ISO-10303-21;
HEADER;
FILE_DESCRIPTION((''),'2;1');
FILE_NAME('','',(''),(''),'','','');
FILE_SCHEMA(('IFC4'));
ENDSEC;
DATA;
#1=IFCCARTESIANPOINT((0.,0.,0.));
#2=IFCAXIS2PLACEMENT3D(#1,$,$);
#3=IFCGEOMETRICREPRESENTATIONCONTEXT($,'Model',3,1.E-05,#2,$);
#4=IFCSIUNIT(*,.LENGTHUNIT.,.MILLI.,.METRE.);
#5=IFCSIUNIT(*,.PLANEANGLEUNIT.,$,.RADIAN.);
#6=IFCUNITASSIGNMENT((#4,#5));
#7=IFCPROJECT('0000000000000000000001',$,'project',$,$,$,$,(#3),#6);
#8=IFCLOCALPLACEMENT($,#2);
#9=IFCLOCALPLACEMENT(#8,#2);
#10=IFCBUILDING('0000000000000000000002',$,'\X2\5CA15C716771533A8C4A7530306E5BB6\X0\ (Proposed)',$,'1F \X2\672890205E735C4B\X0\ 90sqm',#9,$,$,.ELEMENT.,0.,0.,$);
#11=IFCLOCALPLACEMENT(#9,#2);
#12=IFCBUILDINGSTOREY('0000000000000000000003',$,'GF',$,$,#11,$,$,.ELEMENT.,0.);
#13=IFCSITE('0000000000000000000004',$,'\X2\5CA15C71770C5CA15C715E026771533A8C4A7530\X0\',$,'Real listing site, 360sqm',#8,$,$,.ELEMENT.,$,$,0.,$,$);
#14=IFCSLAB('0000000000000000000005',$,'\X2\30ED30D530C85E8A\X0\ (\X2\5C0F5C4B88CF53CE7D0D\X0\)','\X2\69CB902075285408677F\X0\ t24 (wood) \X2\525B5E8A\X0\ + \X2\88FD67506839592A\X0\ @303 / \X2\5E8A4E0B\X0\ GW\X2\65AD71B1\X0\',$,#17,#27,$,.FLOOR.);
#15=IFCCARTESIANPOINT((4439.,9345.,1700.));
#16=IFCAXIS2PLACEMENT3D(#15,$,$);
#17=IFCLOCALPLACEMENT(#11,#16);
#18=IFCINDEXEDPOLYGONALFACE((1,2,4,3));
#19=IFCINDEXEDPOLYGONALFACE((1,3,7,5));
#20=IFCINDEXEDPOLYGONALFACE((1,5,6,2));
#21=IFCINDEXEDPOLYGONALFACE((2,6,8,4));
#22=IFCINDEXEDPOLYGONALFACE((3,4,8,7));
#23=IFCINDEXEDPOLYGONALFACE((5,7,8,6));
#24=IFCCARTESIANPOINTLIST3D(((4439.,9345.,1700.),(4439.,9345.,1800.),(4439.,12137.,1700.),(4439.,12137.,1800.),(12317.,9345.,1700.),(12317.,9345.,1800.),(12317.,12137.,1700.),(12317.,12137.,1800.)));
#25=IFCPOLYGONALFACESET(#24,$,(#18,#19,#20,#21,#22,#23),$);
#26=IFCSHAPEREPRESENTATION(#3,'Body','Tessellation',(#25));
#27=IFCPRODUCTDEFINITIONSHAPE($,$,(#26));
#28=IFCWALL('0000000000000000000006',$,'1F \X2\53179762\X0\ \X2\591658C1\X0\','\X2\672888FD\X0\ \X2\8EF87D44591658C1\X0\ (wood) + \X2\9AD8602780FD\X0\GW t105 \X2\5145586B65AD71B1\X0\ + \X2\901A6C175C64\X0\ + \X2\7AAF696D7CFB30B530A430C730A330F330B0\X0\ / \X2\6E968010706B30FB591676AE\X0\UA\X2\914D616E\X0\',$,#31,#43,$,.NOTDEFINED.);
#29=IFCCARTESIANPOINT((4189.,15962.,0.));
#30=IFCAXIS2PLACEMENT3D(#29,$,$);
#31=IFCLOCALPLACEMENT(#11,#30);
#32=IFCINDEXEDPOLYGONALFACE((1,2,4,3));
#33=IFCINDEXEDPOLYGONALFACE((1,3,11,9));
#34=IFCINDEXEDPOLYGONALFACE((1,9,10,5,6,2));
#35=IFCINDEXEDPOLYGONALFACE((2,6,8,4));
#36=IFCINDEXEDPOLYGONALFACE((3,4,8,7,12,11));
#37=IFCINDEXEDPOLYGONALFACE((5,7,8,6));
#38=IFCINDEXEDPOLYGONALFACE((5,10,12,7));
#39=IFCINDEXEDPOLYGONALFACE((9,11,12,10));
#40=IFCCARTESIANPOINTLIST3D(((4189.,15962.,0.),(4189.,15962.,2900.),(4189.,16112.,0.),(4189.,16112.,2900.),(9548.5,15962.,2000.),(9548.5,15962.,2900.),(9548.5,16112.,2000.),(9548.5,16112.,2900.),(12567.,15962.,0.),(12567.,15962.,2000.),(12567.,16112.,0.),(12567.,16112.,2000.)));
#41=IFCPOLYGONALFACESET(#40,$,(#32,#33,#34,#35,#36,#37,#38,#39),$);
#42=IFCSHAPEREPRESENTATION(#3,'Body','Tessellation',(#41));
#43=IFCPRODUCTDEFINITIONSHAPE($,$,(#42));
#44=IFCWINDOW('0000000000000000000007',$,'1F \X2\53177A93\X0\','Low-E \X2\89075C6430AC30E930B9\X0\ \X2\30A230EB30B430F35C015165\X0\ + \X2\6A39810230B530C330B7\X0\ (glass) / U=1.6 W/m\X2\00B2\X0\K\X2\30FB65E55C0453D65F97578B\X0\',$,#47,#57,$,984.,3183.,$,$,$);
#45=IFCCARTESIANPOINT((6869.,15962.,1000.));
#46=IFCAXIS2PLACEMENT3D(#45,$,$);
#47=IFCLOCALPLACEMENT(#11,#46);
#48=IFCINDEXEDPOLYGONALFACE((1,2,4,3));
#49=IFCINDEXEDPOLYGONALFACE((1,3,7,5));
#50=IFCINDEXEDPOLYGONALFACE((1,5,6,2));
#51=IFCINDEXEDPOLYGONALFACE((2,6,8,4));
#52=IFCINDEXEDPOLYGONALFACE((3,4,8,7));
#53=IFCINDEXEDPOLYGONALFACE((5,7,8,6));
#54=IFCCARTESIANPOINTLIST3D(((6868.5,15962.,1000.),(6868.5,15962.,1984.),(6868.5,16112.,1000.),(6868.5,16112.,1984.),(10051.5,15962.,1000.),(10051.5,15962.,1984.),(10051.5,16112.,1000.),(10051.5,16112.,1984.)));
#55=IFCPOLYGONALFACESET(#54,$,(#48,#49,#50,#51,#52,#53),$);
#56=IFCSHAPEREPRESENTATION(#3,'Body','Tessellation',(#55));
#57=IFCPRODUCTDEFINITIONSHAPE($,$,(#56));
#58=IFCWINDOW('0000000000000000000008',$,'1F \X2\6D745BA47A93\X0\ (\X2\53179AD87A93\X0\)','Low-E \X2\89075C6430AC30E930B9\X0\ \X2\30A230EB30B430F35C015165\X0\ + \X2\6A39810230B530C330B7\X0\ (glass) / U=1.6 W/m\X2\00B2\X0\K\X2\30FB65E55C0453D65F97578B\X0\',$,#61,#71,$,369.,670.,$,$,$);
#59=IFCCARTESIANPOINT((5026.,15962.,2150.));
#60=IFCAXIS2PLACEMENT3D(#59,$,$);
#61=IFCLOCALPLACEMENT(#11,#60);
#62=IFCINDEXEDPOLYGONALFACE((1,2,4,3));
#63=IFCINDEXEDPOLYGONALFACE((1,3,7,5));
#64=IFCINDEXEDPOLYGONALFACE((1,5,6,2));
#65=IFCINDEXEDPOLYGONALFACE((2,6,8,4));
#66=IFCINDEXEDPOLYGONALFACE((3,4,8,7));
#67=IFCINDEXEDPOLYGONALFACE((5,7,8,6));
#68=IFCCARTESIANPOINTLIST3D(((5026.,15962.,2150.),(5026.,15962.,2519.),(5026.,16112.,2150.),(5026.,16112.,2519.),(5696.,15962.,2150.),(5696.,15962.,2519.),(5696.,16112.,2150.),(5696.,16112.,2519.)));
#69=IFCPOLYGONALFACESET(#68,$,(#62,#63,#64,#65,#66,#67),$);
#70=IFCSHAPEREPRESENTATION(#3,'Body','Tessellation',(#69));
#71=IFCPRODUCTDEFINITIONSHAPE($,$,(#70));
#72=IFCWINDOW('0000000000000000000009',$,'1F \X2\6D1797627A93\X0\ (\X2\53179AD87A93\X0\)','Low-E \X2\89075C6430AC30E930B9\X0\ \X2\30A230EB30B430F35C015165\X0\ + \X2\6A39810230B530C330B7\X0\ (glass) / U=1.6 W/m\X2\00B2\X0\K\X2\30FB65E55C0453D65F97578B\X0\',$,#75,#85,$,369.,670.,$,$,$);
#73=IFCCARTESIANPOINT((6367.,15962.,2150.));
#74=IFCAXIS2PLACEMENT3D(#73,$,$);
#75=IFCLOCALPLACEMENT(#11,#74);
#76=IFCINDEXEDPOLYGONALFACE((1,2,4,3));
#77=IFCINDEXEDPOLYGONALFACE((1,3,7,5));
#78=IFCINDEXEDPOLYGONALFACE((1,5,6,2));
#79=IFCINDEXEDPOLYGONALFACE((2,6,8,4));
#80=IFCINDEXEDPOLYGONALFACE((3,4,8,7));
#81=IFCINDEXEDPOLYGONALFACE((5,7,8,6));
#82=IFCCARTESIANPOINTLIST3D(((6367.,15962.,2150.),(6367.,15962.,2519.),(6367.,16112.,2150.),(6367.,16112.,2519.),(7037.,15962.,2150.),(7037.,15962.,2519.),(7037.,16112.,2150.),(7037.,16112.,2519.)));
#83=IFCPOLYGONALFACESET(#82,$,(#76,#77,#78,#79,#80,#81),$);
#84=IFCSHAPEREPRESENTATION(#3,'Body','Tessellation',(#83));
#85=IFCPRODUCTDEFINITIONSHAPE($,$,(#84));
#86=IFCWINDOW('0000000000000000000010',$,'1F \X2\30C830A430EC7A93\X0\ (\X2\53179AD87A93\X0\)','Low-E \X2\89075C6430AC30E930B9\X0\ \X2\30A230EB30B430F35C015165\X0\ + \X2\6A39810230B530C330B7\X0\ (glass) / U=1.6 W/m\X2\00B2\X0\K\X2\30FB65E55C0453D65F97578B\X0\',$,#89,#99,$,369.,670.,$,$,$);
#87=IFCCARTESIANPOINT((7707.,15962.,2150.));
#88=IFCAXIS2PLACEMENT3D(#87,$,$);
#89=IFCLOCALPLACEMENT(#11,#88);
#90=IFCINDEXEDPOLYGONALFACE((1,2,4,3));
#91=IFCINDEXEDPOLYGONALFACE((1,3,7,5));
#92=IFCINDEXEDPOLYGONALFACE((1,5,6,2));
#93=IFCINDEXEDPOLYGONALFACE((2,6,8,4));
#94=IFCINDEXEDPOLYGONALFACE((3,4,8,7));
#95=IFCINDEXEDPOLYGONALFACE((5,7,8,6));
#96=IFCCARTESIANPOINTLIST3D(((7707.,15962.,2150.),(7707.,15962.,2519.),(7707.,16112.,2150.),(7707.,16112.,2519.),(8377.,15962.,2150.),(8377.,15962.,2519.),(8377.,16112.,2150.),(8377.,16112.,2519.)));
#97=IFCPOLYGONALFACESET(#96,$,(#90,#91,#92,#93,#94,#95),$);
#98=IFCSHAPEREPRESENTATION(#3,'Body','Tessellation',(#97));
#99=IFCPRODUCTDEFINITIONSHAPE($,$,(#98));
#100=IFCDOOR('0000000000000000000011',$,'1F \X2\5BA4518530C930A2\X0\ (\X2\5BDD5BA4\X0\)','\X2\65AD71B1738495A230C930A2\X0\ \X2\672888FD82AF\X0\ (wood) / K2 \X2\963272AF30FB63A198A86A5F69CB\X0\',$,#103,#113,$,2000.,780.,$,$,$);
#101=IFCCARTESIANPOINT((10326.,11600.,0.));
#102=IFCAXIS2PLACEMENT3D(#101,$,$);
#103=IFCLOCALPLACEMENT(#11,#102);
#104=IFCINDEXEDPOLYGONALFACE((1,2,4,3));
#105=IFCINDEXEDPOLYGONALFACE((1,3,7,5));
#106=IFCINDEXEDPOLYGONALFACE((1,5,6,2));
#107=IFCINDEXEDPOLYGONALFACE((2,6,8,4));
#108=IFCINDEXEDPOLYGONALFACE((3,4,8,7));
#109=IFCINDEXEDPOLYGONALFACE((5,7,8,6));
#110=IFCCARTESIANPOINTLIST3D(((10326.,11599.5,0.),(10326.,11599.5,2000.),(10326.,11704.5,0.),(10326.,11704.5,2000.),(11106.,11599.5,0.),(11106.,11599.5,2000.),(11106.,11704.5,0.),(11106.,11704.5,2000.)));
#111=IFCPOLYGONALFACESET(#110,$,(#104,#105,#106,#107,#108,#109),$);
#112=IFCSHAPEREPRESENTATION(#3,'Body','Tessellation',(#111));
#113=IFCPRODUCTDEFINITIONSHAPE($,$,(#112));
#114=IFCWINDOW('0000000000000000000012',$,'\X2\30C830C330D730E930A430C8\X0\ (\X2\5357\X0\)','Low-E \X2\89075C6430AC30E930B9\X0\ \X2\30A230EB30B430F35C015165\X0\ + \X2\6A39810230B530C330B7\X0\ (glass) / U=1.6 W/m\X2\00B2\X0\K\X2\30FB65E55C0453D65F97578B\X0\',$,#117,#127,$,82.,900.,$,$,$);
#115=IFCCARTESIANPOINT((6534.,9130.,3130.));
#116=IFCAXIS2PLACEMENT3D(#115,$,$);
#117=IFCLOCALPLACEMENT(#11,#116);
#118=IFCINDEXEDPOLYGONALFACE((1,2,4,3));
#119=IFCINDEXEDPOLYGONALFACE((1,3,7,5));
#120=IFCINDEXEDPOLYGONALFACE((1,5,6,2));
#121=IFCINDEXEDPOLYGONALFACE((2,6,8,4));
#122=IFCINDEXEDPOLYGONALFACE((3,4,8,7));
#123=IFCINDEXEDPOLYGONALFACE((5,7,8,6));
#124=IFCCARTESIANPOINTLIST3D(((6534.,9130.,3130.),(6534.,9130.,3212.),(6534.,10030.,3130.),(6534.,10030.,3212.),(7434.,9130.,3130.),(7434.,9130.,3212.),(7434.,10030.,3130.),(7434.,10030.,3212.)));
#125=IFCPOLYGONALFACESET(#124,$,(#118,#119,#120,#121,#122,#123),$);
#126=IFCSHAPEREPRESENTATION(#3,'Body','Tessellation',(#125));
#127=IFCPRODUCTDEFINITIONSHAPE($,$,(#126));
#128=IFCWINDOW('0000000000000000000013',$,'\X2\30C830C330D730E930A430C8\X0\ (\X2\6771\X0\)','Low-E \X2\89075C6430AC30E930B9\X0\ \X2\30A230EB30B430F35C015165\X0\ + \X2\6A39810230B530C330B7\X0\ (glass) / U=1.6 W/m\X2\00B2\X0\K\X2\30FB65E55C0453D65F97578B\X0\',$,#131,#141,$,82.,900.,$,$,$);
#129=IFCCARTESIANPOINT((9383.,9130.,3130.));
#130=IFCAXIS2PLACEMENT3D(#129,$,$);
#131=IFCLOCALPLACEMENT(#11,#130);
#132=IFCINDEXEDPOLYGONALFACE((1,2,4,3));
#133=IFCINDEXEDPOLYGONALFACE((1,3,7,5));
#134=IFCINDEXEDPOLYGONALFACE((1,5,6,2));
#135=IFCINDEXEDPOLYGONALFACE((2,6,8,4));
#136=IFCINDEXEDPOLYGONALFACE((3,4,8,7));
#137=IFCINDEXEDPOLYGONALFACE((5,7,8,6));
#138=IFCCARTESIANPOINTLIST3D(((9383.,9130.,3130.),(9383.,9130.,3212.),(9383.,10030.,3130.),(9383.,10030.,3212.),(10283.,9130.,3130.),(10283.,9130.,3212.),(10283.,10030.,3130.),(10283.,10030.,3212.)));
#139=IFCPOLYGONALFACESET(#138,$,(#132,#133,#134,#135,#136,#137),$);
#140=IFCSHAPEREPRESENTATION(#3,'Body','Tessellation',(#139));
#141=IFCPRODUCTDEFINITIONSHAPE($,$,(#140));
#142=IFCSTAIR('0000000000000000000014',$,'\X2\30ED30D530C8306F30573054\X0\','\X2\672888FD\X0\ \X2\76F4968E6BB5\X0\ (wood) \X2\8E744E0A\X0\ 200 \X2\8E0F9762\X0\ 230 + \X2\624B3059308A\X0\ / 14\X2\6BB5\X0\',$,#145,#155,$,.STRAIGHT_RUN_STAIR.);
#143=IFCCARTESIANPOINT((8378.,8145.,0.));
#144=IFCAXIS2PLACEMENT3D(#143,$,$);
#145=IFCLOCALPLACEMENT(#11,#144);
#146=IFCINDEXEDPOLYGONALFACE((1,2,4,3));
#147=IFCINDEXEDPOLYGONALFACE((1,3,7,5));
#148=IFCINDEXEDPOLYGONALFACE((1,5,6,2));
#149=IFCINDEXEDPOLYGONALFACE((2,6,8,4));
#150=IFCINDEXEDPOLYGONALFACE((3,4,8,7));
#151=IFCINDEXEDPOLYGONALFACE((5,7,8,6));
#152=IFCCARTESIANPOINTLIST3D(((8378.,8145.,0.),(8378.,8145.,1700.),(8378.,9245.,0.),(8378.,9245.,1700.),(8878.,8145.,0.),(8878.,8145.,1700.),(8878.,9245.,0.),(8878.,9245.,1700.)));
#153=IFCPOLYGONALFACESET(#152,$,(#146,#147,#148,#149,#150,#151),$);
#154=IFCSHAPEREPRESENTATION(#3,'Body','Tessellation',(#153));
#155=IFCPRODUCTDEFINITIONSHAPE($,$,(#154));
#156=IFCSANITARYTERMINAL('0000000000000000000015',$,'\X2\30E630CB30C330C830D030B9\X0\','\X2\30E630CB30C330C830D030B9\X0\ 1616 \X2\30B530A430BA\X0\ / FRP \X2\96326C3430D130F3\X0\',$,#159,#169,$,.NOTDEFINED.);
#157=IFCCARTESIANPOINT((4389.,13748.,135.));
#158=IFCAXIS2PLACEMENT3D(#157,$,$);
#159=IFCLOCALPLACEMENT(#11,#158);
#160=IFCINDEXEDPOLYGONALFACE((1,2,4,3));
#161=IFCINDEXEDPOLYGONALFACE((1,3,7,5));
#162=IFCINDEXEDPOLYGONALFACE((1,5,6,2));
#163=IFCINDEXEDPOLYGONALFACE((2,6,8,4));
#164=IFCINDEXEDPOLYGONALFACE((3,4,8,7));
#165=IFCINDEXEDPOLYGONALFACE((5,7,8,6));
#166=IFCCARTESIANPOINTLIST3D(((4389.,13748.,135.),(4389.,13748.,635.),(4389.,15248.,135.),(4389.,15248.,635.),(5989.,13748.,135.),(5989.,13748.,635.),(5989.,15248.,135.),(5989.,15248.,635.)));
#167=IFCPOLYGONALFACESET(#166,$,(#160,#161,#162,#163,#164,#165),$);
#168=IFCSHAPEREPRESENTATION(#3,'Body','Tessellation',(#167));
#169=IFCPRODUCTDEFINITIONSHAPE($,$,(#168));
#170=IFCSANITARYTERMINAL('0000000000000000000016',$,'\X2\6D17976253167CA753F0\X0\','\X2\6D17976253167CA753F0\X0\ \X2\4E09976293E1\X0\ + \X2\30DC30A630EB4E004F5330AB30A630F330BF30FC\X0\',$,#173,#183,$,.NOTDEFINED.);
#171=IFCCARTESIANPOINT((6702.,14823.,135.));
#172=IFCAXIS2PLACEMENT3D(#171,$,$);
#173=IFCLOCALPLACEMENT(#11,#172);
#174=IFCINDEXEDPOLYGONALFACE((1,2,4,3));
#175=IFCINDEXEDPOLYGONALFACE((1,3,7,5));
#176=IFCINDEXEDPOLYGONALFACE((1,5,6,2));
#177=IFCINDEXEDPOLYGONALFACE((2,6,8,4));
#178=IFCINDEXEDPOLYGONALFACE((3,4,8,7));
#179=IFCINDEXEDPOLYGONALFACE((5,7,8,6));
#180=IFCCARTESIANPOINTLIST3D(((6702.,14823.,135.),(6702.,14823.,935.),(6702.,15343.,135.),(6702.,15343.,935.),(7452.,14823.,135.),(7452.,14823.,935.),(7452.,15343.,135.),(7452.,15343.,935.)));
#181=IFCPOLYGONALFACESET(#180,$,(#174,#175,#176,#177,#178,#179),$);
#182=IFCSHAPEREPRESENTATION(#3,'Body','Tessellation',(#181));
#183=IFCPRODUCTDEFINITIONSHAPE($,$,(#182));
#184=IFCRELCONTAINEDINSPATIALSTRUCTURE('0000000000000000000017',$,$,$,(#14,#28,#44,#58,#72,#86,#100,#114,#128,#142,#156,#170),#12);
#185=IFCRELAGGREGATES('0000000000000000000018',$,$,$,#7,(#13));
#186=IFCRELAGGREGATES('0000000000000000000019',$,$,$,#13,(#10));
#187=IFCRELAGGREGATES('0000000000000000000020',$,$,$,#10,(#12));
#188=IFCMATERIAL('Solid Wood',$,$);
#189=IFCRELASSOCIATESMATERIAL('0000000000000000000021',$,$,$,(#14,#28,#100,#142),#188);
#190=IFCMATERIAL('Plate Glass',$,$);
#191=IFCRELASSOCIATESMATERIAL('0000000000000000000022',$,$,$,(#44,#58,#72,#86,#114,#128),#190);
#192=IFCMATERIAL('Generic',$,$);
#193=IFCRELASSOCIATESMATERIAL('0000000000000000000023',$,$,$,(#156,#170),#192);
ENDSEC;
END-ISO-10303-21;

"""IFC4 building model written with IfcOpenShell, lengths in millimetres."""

from ifc_helpers import new_model, si_unit, frame, frame_2d, origin, place, context, project, spatial, rectangle, extrude, material, element, fill, save


model = new_model("IFC4")

# Units and contexts
model_context = context("Model", 3, precision=1e-05, world=origin())
ifc_project = project(units=[si_unit("LENGTHUNIT", "METRE", prefix="MILLI"), si_unit("PLANEANGLEUNIT", "RADIAN")], contexts=[model_context])

# Site, building, storey
site_placement = place(None, origin())
site = spatial("IfcSite", under=ifc_project, at=site_placement, Name="岡山県岡山市東区豊田", ObjectType="Real listing site, 360sqm", CompositionType="ELEMENT", RefElevation=0.0)
building_placement = place(site_placement, origin())
building = spatial("IfcBuilding", under=site, at=building_placement, Name="岡山東区豊田の家 (Proposed)", ObjectType="1F 木造平屋 90sqm", CompositionType="ELEMENT", ElevationOfRefHeight=0.0, ElevationOfTerrain=0.0)
storey_placement = place(building_placement, origin())
storey = spatial("IfcBuildingStorey", under=building, at=storey_placement, Name="GF", CompositionType="ELEMENT", Elevation=0.0)

# Slab
ifc_material_1 = material(Name="Solid Wood")
slab_placement = place(storey_placement, frame((4439.0, 9345.0, 1700.0)))
element("IfcSlab", 1, at=slab_placement, inside=storey, material=ifc_material_1, Name="ロフト床 (小屋裏収納)", Description="構造用合板 t24 (wood) 剛床 + 製材根太 @303 / 床下 GW断熱", PredefinedType="FLOOR", context=model_context, shape_type="SweptSolid", body=[
    extrude(rectangle(XDim=7878.0, YDim=2792.0, at=frame_2d((3939.0, 1396.0))), frame((4439.0, 9345.0, 1700.0)), (0.0, 0.0, 1.0), 100.0),
])

# Wall, openings, windows
wall_1_placement = place(storey_placement, frame((4189.0, 15962.0, 0.0)))
wall_1 = element("IfcWall", 2, at=wall_1_placement, inside=storey, material=ifc_material_1, Name="1F 北面 外壁", Description="木製 軸組外壁 (wood) + 高性能GW t105 充填断熱 + 通気層 + 窯業系サイディング / 準耐火・外皮UA配慮", PredefinedType="NOTDEFINED", context=model_context, shape_type="SweptSolid", body=[
    extrude(rectangle(XDim=8378.0, YDim=150.0, at=frame_2d((4189.0, 75.0))), frame((4189.0, 15962.0, 0.0)), (0.0, 0.0, 1.0), 2900.0),
])
opening_1_placement = place(storey_placement, frame((6869.0, 15962.0, 1000.0)))
opening_1 = element("IfcOpeningElement", 3, at=opening_1_placement, cuts=wall_1, PredefinedType="NOTDEFINED", context=model_context, shape_type="SweptSolid", body=[
    extrude(rectangle(XDim=3183.0, YDim=150.0, at=frame_2d((1591.0, 75.0))), frame((6869.0, 15962.0, 1000.0)), (0.0, 0.0, 1.0), 984.0),
])
opening_2_placement = place(storey_placement, frame((5026.0, 15962.0, 2150.0)))
opening_2 = element("IfcOpeningElement", 4, at=opening_2_placement, cuts=wall_1, PredefinedType="NOTDEFINED", context=model_context, shape_type="SweptSolid", body=[
    extrude(rectangle(XDim=670.0, YDim=150.0, at=frame_2d((335.0, 75.0))), frame((5026.0, 15962.0, 2150.0)), (0.0, 0.0, 1.0), 369.0),
])
opening_3_placement = place(storey_placement, frame((6367.0, 15962.0, 2150.0)))
opening_3 = element("IfcOpeningElement", 5, at=opening_3_placement, cuts=wall_1, PredefinedType="NOTDEFINED", context=model_context, shape_type="SweptSolid", body=[
    extrude(rectangle(XDim=670.0, YDim=150.0, at=frame_2d((335.0, 75.0))), frame((6367.0, 15962.0, 2150.0)), (0.0, 0.0, 1.0), 369.0),
])
opening_4_placement = place(storey_placement, frame((7707.0, 15962.0, 2150.0)))
opening_4 = element("IfcOpeningElement", 6, at=opening_4_placement, cuts=wall_1, PredefinedType="NOTDEFINED", context=model_context, shape_type="SweptSolid", body=[
    extrude(rectangle(XDim=670.0, YDim=150.0, at=frame_2d((335.0, 75.0))), frame((7707.0, 15962.0, 2150.0)), (0.0, 0.0, 1.0), 369.0),
])
ifc_material_2 = material(Name="Plate Glass")
window_1_placement = place(storey_placement, frame((6869.0, 15962.0, 1000.0)))
window_1 = element("IfcWindow", 7, at=window_1_placement, inside=storey, material=ifc_material_2, Name="1F 北窓", Description="Low-E 複層ガラス アルゴン封入 + 樹脂サッシ (glass) / U=1.6 W/m²K・日射取得型", OverallHeight=984.0, OverallWidth=3183.0, context=model_context, shape_type="SweptSolid", body=[
    extrude(rectangle(XDim=3183.0, YDim=150.0, at=frame_2d((1591.0, 75.0))), frame((6869.0, 15962.0, 1000.0)), (0.0, 0.0, 1.0), 984.0),
])
fill(opening_1, window_1)
window_2_placement = place(storey_placement, frame((5026.0, 15962.0, 2150.0)))
window_2 = element("IfcWindow", 8, at=window_2_placement, inside=storey, material=ifc_material_2, Name="1F 浴室窓 (北高窓)", Description="Low-E 複層ガラス アルゴン封入 + 樹脂サッシ (glass) / U=1.6 W/m²K・日射取得型", OverallHeight=369.0, OverallWidth=670.0, context=model_context, shape_type="SweptSolid", body=[
    extrude(rectangle(XDim=670.0, YDim=150.0, at=frame_2d((335.0, 75.0))), frame((5026.0, 15962.0, 2150.0)), (0.0, 0.0, 1.0), 369.0),
])
fill(opening_2, window_2)
window_3_placement = place(storey_placement, frame((6367.0, 15962.0, 2150.0)))
window_3 = element("IfcWindow", 9, at=window_3_placement, inside=storey, material=ifc_material_2, Name="1F 洗面窓 (北高窓)", Description="Low-E 複層ガラス アルゴン封入 + 樹脂サッシ (glass) / U=1.6 W/m²K・日射取得型", OverallHeight=369.0, OverallWidth=670.0, context=model_context, shape_type="SweptSolid", body=[
    extrude(rectangle(XDim=670.0, YDim=150.0, at=frame_2d((335.0, 75.0))), frame((6367.0, 15962.0, 2150.0)), (0.0, 0.0, 1.0), 369.0),
])
fill(opening_3, window_3)
window_4_placement = place(storey_placement, frame((7707.0, 15962.0, 2150.0)))
window_4 = element("IfcWindow", 10, at=window_4_placement, inside=storey, material=ifc_material_2, Name="1F トイレ窓 (北高窓)", Description="Low-E 複層ガラス アルゴン封入 + 樹脂サッシ (glass) / U=1.6 W/m²K・日射取得型", OverallHeight=369.0, OverallWidth=670.0, context=model_context, shape_type="SweptSolid", body=[
    extrude(rectangle(XDim=670.0, YDim=150.0, at=frame_2d((335.0, 75.0))), frame((7707.0, 15962.0, 2150.0)), (0.0, 0.0, 1.0), 369.0),
])
fill(opening_4, window_4)

# Door
door_1_placement = place(storey_placement, frame((10326.0, 11600.0, 0.0)))
element("IfcDoor", 11, at=door_1_placement, inside=storey, material=ifc_material_1, Name="1F 室内ドア (寝室)", Description="断熱玄関ドア 木製芯 (wood) / K2 防犯・採風機構", OverallHeight=2000.0, OverallWidth=780.0, context=model_context, shape_type="SweptSolid", body=[
    extrude(rectangle(XDim=780.0, YDim=105.0, at=frame_2d((390.0, 52.0))), frame((10326.0, 11600.0, 0.0)), (0.0, 0.0, 1.0), 2000.0),
])

# Windows
window_5_placement = place(storey_placement, frame((6534.0, 9130.0, 3130.0)))
element("IfcWindow", 12, at=window_5_placement, inside=storey, material=ifc_material_2, Name="トップライト (南)", Description="Low-E 複層ガラス アルゴン封入 + 樹脂サッシ (glass) / U=1.6 W/m²K・日射取得型", OverallHeight=82.0, OverallWidth=900.0, context=model_context, shape_type="SweptSolid", body=[
    extrude(rectangle(XDim=900.0, YDim=900.0, at=frame_2d((450.0, 450.0))), frame((6534.0, 9130.0, 3130.0)), (0.0, 0.0, 1.0), 82.0),
])
window_6_placement = place(storey_placement, frame((9383.0, 9130.0, 3130.0)))
element("IfcWindow", 13, at=window_6_placement, inside=storey, material=ifc_material_2, Name="トップライト (東)", Description="Low-E 複層ガラス アルゴン封入 + 樹脂サッシ (glass) / U=1.6 W/m²K・日射取得型", OverallHeight=82.0, OverallWidth=900.0, context=model_context, shape_type="SweptSolid", body=[
    extrude(rectangle(XDim=900.0, YDim=900.0, at=frame_2d((450.0, 450.0))), frame((9383.0, 9130.0, 3130.0)), (0.0, 0.0, 1.0), 82.0),
])

# Stair
stair_placement = place(storey_placement, frame((8378.0, 8145.0, 0.0)))
element("IfcStair", 14, at=stair_placement, inside=storey, material=ifc_material_1, Name="ロフトはしご", Description="木製 直階段 (wood) 蹴上 200 踏面 230 + 手すり / 14段", PredefinedType="STRAIGHT_RUN_STAIR", context=model_context, shape_type="SweptSolid", body=[
    extrude(rectangle(XDim=500.0, YDim=1100.0, at=frame_2d((250.0, 550.0))), frame((8378.0, 8145.0, 0.0)), (0.0, 0.0, 1.0), 1700.0),
])

# Sanitary terminals
ifc_material_3 = material(Name="Generic")
sanitary_terminal_1_placement = place(storey_placement, frame((4389.0, 13748.0, 135.0)))
element("IfcSanitaryTerminal", 15, at=sanitary_terminal_1_placement, inside=storey, material=ifc_material_3, Name="ユニットバス", Description="ユニットバス 1616 サイズ / FRP 防水パン", PredefinedType="NOTDEFINED", context=model_context, shape_type="SweptSolid", body=[
    extrude(rectangle(XDim=1600.0, YDim=1500.0, at=frame_2d((800.0, 750.0))), frame((4389.0, 13748.0, 135.0)), (0.0, 0.0, 1.0), 500.0),
])
sanitary_terminal_2_placement = place(storey_placement, frame((6702.0, 14823.0, 135.0)))
element("IfcSanitaryTerminal", 16, at=sanitary_terminal_2_placement, inside=storey, material=ifc_material_3, Name="洗面化粧台", Description="洗面化粧台 三面鏡 + ボウル一体カウンター", PredefinedType="NOTDEFINED", context=model_context, shape_type="SweptSolid", body=[
    extrude(rectangle(XDim=750.0, YDim=520.0, at=frame_2d((375.0, 260.0))), frame((6702.0, 14823.0, 135.0)), (0.0, 0.0, 1.0), 800.0),
])

save(model, "model.ifc")
